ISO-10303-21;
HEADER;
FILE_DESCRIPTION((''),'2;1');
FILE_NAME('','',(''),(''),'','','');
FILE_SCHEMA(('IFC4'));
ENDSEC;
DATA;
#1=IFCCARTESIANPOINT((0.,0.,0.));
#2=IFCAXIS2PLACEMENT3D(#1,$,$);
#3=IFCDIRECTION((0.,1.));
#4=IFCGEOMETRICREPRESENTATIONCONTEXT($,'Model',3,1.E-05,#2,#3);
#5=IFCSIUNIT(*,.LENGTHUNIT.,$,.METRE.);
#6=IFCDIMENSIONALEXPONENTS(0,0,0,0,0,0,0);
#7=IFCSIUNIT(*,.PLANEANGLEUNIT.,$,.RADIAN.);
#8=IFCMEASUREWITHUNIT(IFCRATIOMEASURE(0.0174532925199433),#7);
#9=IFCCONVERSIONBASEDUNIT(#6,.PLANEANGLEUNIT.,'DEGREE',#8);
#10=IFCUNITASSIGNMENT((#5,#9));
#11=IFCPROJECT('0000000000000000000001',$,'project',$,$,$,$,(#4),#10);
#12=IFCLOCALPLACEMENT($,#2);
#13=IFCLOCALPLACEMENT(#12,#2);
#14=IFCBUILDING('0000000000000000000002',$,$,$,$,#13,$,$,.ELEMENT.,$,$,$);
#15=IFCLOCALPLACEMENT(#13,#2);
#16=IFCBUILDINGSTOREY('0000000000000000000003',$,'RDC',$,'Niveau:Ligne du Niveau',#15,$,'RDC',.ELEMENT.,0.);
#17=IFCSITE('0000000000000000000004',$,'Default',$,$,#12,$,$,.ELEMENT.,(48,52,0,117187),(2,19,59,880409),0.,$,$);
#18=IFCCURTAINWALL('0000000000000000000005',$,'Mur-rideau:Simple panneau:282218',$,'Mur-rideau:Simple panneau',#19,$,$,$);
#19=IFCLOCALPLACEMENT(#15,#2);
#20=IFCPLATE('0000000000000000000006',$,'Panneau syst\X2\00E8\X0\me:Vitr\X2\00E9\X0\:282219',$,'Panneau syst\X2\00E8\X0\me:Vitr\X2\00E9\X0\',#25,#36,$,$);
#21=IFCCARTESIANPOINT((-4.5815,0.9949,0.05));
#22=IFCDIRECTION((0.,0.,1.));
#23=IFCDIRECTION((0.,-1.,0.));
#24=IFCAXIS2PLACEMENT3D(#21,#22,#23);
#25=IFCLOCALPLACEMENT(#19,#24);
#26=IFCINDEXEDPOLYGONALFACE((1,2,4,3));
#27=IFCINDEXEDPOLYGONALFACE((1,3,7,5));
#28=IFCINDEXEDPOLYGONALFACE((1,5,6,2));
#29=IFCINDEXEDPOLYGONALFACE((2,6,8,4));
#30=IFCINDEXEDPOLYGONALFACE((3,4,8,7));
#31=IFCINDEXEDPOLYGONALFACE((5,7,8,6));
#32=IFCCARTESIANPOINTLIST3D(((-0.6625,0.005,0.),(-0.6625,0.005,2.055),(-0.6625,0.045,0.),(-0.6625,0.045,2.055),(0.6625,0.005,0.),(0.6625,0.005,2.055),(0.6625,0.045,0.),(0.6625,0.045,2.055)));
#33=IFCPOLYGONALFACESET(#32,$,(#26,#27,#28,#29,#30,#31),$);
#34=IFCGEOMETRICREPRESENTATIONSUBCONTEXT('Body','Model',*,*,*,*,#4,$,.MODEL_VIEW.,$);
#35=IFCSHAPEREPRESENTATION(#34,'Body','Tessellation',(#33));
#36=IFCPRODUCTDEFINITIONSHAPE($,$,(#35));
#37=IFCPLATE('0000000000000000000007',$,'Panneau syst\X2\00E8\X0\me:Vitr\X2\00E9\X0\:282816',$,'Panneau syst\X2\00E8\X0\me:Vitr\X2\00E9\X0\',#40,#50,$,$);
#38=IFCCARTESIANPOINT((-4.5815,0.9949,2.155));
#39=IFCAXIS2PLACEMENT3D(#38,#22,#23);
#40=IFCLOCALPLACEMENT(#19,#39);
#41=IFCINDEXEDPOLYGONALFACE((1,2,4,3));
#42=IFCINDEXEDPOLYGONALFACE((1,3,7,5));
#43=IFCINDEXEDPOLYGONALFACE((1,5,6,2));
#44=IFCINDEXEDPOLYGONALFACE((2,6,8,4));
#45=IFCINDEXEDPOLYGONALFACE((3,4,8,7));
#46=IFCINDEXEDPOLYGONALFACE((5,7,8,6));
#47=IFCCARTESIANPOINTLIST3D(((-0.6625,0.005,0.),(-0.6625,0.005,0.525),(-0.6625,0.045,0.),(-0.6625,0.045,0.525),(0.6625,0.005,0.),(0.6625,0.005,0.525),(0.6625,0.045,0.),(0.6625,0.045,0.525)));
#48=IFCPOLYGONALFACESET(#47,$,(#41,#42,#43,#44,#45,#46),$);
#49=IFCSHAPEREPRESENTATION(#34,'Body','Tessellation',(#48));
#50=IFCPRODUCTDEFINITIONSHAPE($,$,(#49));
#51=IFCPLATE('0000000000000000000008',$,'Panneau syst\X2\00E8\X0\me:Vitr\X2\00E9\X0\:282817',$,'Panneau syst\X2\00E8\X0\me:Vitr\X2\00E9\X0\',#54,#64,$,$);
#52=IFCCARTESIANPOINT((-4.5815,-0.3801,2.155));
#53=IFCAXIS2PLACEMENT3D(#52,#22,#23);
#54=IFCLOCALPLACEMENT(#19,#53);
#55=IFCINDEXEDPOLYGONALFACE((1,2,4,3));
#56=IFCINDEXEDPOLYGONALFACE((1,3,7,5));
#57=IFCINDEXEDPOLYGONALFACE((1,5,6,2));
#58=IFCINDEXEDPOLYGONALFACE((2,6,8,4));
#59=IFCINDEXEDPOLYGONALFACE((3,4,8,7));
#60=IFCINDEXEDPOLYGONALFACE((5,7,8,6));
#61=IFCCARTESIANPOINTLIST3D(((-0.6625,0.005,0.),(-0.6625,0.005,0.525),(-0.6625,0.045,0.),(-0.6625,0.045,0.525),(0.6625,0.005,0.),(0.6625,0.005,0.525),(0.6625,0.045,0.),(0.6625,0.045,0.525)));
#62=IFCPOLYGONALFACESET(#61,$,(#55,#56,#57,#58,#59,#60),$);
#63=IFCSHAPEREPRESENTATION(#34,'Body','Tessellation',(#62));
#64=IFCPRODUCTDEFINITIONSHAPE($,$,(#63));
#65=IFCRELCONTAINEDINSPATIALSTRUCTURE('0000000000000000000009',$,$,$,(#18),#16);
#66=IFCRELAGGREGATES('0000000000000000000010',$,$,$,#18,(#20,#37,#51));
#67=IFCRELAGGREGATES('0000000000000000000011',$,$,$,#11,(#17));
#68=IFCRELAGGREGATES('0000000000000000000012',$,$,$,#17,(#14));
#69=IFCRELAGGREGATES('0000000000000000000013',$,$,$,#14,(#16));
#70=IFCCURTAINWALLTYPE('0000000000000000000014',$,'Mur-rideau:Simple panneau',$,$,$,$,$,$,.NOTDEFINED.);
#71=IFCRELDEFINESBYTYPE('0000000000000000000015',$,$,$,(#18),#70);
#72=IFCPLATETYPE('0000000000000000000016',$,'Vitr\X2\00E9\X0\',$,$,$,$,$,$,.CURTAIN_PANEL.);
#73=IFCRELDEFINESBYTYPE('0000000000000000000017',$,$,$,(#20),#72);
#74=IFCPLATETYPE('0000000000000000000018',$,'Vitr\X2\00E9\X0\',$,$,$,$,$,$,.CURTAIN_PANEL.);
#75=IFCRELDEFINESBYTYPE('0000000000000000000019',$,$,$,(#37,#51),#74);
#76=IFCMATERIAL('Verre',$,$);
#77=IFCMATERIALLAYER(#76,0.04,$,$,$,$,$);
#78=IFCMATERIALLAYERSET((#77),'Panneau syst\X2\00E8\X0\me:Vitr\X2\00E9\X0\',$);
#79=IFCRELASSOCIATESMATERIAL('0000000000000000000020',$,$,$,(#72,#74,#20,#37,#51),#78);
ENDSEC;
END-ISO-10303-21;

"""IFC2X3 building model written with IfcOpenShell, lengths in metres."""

from ifc_helpers import new_model, entity, si_unit, converted_unit, direction, frame, frame_2d, origin, place, context, subcontext, project, spatial, rectangle, extrude, source, transform, mapped, material, layer, layer_set, layer_usage, type_object, type_shapes, element, aggregate, save


model = new_model("IFC2X3")

# Units and contexts
model_context = context("Model", 3, precision=1e-05, world=origin(), true_north=direction((0.0, 1.0)))
body_context = subcontext(model_context, "Body", "Model", "MODEL_VIEW")
ifc_project = project(units=[si_unit("LENGTHUNIT", "METRE"), converted_unit("PLANEANGLEUNIT", "DEGREE", entity("IfcRatioMeasure", 0.0174532925199433), si_unit("PLANEANGLEUNIT", "RADIAN"), dimensions=[0, 0, 0, 0, 0, 0, 0])], contexts=[model_context])

# Site, building, storey
site_placement = place(None, origin())
site = spatial("IfcSite", under=ifc_project, at=site_placement, Name="Default", CompositionType="ELEMENT", RefLatitude=(48, 52, 0, 117187), RefLongitude=(2, 19, 59, 880409), RefElevation=0.0)
building_placement = place(site_placement, origin())
building = spatial("IfcBuilding", under=site, at=building_placement, CompositionType="ELEMENT")
storey_placement = place(building_placement, origin())
storey = spatial("IfcBuildingStorey", under=building, at=storey_placement, Name="RDC", ObjectType="Niveau:Ligne du Niveau", LongName="RDC", CompositionType="ELEMENT", Elevation=0.0)

# Curtain wall
curtain_wall_type = type_object("IfcCurtainWallType", Name="Mur-rideau:Simple panneau", PredefinedType="NOTDEFINED")
curtain_wall_placement = place(storey_placement, origin())
curtain_wall = element("IfcCurtainWall", 1, at=curtain_wall_placement, inside=storey, type_object=curtain_wall_type, Name="Mur-rideau:Simple panneau:282218", ObjectType="Mur-rideau:Simple panneau")

# Plates
ifc_material_1 = material(Name="Verre")
ifc_layer_1 = layer(ifc_material_1, 0.04)
ifc_layer_set_1 = layer_set([ifc_layer_1], Name="Panneau système:Vitré")
ifc_layer_usage_1 = layer_usage(ifc_layer_set_1, "AXIS3", "POSITIVE", 0.082)
plate_type_1 = type_object("IfcPlateType", Name="Vitré", PredefinedType="CURTAIN_PANEL", material=ifc_layer_set_1)
shared_shape_1 = source(origin(), body_context, "Body", "SweptSolid", [
    extrude(rectangle(XDim=0.04, YDim=1.325, at=frame_2d((0.0, 0.0), x_axis=(1.0, 0.0))), frame((0.0, 0.025, 0.0), z_axis=(0.0, 0.0, 1.0), x_axis=(0.0, 1.0, 0.0)), (0.0, 0.0, 1.0), 2.055),
])
type_shapes(plate_type_1, [shared_shape_1])
plate_1_placement = place(curtain_wall_placement, frame((-4.5815, 0.9949, 0.05), z_axis=(0.0, 0.0, 1.0), x_axis=(0.0, -1.0, 0.0)))
plate_1 = element("IfcPlate", 2, at=plate_1_placement, type_object=plate_type_1, material=ifc_layer_usage_1, Name="Panneau système:Vitré:282219", ObjectType="Panneau système:Vitré", context=body_context, shape_type="MappedRepresentation", body=[
    mapped(shared_shape_1, transform((0.0, 0.0, 0.0), scale=1.0)),
])
ifc_layer_usage_2 = layer_usage(ifc_layer_set_1, "AXIS3", "POSITIVE", 0.082)
plate_type_2 = type_object("IfcPlateType", Name="Vitré", PredefinedType="CURTAIN_PANEL", material=ifc_layer_set_1)
shared_shape_2 = source(origin(), body_context, "Body", "SweptSolid", [
    extrude(rectangle(XDim=0.04, YDim=1.325, at=frame_2d((0.0, 0.0), x_axis=(1.0, 0.0))), frame((0.0, 0.025, 0.0), z_axis=(0.0, 0.0, 1.0), x_axis=(0.0, 1.0, 0.0)), (0.0, 0.0, 1.0), 0.525),
])
type_shapes(plate_type_2, [shared_shape_2])
plate_2_placement = place(curtain_wall_placement, frame((-4.5815, 0.9949, 2.155), z_axis=(0.0, 0.0, 1.0), x_axis=(0.0, -1.0, 0.0)))
plate_2 = element("IfcPlate", 3, at=plate_2_placement, type_object=plate_type_2, material=ifc_layer_usage_2, Name="Panneau système:Vitré:282816", ObjectType="Panneau système:Vitré", context=body_context, shape_type="MappedRepresentation", body=[
    mapped(shared_shape_2, transform((0.0, 0.0, 0.0), scale=1.0)),
])
ifc_layer_usage_3 = layer_usage(ifc_layer_set_1, "AXIS3", "POSITIVE", 0.082)
plate_3_placement = place(curtain_wall_placement, frame((-4.5815, -0.3801, 2.155), z_axis=(0.0, 0.0, 1.0), x_axis=(0.0, -1.0, 0.0)))
plate_3 = element("IfcPlate", 4, at=plate_3_placement, type_object=plate_type_2, material=ifc_layer_usage_3, Name="Panneau système:Vitré:282817", ObjectType="Panneau système:Vitré", context=body_context, shape_type="MappedRepresentation", body=[
    mapped(shared_shape_2, transform((0.0, 0.0, 0.0), scale=1.0)),
])
aggregate(curtain_wall, [plate_1, plate_2, plate_3])

save(model, "model.ifc")
